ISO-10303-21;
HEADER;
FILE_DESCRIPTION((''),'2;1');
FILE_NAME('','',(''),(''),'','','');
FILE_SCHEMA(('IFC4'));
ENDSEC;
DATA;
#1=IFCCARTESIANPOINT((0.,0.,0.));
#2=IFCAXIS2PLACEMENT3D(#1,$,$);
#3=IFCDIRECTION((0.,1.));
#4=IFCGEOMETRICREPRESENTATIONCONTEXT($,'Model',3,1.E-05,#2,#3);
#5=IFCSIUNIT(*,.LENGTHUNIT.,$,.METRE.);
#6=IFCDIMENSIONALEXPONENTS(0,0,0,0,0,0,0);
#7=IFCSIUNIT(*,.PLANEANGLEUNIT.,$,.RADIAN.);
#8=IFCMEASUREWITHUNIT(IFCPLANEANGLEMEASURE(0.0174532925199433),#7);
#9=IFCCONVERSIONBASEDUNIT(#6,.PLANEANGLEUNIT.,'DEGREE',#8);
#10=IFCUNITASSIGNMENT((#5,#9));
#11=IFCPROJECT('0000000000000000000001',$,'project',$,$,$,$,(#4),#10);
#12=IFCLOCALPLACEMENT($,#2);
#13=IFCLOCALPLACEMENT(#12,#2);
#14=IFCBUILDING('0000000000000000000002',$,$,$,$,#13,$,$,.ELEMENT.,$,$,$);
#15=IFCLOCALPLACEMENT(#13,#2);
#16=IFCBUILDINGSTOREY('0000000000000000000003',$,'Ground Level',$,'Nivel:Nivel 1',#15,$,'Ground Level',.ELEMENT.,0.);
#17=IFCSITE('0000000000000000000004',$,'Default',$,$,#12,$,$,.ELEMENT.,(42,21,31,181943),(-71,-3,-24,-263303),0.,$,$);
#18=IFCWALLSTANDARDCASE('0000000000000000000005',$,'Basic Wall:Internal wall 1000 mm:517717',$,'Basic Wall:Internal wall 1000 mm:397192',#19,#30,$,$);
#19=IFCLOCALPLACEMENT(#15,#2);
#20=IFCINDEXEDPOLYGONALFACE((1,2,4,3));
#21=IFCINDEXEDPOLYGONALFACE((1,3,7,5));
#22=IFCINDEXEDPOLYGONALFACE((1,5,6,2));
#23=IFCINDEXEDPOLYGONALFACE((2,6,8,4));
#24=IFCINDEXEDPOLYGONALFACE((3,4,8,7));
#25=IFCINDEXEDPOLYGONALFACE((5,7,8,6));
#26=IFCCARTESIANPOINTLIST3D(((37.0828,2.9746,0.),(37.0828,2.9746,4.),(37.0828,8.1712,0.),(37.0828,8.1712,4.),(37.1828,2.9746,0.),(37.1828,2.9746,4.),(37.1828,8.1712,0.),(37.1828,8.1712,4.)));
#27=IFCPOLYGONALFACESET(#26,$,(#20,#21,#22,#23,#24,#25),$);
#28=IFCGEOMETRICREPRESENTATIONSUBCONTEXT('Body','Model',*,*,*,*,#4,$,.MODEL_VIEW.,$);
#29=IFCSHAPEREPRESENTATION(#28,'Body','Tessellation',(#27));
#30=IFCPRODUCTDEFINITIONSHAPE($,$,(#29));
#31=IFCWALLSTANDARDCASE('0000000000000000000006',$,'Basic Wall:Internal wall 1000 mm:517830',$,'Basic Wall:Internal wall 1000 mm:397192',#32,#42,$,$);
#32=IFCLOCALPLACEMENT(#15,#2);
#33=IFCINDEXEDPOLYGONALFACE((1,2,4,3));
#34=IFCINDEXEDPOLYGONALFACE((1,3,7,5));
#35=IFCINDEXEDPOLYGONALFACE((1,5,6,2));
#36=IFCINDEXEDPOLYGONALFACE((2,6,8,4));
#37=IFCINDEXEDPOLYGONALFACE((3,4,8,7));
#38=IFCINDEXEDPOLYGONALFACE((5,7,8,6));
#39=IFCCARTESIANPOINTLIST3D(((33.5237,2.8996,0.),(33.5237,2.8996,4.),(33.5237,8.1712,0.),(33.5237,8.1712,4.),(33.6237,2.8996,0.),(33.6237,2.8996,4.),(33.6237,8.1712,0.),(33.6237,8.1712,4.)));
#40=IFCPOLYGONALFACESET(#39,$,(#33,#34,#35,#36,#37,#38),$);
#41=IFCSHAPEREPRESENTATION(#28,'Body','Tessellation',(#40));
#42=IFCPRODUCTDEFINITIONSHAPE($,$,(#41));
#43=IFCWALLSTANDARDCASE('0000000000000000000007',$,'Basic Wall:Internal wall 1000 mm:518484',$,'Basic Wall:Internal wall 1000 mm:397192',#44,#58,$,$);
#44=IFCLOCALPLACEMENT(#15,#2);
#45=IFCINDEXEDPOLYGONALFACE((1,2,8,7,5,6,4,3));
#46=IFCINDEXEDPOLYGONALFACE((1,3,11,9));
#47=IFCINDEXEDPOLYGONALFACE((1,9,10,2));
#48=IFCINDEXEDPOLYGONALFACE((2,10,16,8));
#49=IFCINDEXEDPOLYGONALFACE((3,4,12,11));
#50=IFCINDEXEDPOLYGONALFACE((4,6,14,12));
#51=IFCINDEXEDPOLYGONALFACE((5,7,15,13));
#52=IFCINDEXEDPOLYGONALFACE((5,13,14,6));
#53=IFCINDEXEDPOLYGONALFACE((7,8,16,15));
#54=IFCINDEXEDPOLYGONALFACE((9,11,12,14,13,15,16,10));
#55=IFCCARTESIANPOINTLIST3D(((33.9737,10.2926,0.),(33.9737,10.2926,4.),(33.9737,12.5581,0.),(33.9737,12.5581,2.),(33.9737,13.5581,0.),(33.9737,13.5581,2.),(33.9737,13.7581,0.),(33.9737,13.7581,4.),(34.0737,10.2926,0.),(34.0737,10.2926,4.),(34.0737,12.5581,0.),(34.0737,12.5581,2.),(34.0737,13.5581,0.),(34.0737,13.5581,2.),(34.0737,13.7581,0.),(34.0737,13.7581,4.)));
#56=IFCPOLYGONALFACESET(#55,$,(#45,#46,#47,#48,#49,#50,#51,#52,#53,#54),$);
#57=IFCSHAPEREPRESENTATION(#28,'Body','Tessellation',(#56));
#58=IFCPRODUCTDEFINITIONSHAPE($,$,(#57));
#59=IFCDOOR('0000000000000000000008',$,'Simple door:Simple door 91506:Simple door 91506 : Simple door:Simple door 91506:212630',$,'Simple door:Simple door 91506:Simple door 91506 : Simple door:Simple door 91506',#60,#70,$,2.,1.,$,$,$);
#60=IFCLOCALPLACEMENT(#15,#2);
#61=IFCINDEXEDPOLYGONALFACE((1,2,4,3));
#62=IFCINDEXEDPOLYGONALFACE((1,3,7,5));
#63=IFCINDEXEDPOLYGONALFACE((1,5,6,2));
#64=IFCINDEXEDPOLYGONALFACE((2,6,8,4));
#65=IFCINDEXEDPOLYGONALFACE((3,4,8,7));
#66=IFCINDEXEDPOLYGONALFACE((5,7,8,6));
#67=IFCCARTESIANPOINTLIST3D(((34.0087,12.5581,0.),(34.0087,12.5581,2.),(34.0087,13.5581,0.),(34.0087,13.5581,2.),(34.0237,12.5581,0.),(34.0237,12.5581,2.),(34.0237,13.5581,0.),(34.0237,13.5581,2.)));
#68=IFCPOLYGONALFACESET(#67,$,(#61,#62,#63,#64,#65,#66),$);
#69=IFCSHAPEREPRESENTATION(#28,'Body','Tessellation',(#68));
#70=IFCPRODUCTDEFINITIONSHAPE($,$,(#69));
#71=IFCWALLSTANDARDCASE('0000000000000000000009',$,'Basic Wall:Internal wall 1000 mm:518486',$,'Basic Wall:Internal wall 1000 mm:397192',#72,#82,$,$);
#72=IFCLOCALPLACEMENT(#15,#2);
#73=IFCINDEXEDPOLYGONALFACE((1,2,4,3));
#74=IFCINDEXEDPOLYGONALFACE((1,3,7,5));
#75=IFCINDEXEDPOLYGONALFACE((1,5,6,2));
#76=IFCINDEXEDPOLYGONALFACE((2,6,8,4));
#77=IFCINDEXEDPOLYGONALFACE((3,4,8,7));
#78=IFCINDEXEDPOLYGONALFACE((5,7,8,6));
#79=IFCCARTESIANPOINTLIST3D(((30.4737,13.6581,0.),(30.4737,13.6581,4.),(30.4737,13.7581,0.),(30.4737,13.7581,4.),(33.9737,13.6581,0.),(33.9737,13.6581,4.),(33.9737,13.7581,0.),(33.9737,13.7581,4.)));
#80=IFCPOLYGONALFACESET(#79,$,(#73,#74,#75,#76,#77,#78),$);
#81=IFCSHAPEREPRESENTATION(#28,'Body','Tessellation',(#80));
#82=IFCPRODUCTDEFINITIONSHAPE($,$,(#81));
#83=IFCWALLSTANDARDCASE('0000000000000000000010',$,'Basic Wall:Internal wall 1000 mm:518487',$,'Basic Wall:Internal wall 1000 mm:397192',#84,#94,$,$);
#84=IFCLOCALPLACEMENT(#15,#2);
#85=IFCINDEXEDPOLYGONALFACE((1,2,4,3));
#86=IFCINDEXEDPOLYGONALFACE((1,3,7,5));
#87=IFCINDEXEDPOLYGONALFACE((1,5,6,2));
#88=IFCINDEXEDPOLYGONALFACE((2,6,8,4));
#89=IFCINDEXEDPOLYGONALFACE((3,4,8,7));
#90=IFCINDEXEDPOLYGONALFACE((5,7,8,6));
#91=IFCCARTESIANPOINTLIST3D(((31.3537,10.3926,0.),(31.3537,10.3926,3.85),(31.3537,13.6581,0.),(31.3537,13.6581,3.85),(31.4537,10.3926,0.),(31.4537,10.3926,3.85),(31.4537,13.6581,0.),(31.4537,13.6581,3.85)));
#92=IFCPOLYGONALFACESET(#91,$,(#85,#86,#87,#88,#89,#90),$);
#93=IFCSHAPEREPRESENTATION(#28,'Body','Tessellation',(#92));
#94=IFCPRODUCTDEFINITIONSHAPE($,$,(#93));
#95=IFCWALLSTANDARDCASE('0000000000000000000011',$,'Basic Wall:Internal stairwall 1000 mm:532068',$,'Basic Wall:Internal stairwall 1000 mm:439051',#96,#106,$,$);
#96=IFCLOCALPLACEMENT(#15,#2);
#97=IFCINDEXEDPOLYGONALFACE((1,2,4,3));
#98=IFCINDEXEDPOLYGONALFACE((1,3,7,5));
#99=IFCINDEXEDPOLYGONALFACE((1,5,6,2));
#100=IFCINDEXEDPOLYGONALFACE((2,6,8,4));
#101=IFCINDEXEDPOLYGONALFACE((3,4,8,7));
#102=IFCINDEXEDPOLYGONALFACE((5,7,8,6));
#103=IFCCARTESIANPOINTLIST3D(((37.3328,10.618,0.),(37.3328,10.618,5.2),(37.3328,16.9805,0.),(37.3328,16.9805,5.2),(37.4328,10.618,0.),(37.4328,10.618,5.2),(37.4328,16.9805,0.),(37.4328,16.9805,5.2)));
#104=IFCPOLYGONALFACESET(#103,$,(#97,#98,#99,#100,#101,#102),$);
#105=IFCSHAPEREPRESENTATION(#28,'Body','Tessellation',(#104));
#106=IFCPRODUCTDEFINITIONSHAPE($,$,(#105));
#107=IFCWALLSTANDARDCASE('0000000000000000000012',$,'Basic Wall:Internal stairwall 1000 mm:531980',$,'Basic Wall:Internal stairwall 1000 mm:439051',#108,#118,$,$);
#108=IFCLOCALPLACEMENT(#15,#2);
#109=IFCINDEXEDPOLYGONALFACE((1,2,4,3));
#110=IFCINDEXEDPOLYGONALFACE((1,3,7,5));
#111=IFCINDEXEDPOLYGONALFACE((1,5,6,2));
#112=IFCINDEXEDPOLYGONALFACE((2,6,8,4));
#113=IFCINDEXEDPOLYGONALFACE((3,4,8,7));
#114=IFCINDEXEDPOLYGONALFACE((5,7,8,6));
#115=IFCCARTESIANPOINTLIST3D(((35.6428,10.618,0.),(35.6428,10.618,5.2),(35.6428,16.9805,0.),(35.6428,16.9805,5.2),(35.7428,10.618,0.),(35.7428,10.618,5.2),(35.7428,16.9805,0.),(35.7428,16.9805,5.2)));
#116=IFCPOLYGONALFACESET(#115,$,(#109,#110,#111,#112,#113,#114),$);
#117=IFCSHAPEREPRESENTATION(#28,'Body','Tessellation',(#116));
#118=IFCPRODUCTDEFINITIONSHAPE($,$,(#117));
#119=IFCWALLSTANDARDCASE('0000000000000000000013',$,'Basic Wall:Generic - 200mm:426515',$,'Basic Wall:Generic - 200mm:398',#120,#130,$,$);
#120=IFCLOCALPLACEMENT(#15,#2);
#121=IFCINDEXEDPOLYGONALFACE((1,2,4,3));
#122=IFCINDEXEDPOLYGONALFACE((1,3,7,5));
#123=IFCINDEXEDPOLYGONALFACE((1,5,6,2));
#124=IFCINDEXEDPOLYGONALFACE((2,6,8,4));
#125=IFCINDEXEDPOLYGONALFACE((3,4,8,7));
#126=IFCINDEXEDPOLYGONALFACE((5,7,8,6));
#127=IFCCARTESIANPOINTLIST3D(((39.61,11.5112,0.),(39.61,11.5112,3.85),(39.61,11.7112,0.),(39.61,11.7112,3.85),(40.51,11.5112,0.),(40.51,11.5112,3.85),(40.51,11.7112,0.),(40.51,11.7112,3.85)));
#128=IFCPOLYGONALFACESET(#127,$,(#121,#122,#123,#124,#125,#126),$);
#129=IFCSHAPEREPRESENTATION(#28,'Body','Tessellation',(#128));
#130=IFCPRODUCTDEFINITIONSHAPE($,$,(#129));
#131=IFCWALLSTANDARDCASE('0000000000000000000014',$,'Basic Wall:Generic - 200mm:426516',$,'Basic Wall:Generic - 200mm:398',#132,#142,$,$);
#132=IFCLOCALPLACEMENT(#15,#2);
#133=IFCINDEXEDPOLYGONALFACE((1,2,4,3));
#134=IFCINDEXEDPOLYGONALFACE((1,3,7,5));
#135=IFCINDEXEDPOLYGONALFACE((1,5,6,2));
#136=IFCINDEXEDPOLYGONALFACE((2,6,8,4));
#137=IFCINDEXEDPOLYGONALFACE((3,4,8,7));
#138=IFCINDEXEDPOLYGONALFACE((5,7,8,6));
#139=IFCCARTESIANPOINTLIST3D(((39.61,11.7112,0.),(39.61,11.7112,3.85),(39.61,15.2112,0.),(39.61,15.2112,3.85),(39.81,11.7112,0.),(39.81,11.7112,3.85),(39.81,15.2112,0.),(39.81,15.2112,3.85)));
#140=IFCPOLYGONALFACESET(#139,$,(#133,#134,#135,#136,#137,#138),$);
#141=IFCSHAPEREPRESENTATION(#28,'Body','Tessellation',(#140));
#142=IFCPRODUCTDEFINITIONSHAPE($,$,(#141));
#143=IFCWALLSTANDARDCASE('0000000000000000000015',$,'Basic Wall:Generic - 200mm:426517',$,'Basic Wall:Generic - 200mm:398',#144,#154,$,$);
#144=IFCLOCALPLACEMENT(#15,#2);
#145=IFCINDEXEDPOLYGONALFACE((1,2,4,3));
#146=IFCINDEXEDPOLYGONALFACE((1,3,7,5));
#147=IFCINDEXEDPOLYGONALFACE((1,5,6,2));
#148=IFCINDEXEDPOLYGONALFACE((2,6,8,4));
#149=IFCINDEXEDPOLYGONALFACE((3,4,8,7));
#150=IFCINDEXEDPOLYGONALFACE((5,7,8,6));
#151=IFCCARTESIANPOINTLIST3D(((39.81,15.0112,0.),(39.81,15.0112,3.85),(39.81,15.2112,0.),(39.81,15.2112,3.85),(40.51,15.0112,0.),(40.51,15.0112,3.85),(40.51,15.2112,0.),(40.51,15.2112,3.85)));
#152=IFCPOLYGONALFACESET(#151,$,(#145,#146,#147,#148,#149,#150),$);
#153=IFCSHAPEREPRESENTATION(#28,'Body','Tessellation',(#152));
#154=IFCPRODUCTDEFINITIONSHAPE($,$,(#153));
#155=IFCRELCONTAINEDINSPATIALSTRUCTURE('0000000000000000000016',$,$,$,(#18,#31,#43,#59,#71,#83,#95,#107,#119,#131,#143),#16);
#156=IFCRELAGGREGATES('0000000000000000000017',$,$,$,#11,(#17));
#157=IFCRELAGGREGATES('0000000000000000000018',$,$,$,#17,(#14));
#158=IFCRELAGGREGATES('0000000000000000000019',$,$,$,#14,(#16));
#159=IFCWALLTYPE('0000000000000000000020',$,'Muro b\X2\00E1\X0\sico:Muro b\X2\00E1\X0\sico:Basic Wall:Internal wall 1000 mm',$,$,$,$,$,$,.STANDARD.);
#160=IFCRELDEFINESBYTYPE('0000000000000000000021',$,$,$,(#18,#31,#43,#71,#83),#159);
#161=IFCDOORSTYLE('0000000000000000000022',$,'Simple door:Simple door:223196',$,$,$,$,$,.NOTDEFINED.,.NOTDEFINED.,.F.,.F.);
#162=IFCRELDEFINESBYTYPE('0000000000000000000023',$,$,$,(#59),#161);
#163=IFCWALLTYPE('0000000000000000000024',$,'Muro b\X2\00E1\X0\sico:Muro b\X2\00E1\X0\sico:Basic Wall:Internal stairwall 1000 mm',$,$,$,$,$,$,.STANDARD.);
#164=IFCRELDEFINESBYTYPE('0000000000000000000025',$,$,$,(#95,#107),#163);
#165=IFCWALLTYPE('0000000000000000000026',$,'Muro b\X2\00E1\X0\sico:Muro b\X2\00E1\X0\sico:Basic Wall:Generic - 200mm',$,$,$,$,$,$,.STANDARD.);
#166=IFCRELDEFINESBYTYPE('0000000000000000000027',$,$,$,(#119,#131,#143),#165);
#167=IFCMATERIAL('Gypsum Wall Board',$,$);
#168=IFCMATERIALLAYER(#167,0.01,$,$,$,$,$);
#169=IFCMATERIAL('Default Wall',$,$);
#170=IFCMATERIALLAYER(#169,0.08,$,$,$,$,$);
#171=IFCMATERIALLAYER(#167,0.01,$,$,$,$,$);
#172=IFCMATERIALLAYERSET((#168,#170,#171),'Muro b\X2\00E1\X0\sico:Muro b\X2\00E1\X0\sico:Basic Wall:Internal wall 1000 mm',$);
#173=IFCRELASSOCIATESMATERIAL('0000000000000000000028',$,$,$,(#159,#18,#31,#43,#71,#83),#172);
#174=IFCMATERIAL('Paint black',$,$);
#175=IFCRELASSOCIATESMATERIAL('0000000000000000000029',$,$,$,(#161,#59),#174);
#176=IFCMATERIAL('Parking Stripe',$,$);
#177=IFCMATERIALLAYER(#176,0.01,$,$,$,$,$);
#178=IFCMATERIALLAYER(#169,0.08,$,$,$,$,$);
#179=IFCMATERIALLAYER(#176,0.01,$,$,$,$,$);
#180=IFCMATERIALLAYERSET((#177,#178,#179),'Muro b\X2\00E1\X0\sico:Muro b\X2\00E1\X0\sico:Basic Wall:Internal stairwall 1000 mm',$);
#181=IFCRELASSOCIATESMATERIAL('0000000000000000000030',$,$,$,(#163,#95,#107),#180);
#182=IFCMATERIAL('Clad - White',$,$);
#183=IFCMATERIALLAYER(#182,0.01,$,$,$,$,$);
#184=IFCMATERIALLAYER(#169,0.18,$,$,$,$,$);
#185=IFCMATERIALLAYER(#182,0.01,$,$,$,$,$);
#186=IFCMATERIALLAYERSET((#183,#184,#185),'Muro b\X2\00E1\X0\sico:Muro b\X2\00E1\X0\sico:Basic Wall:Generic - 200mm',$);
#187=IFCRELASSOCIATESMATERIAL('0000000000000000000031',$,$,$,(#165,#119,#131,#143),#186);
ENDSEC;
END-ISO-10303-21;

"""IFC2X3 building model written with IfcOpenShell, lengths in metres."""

from ifc_helpers import new_model, entity, si_unit, converted_unit, direction, frame, frame_2d, origin, origin_2d_with_axis, place, context, subcontext, project, spatial, rectangle, extrude, source, transform, mapped, material, layer, layer_set, layer_usage, type_object, type_shapes, element, fill, save


model = new_model("IFC2X3")

# Units and contexts
model_context = context("Model", 3, precision=1e-05, world=origin(), true_north=direction((0.0, 1.0)))
body_context = subcontext(model_context, "Body", "Model", "MODEL_VIEW")
ifc_project = project(units=[si_unit("LENGTHUNIT", "METRE"), converted_unit("PLANEANGLEUNIT", "DEGREE", entity("IfcPlaneAngleMeasure", 0.0174532925199433), si_unit("PLANEANGLEUNIT", "RADIAN"), dimensions=[0, 0, 0, 0, 0, 0, 0])], contexts=[model_context])

# Site, building, storey
site_placement = place(None, origin())
site = spatial("IfcSite", under=ifc_project, at=site_placement, Name="Default", CompositionType="ELEMENT", RefLatitude=(42, 21, 31, 181943), RefLongitude=(-71, -3, -24, -263303), RefElevation=0.0)
building_placement = place(site_placement, origin())
building = spatial("IfcBuilding", under=site, at=building_placement, CompositionType="ELEMENT")
storey_placement = place(building_placement, origin())
storey = spatial("IfcBuildingStorey", under=building, at=storey_placement, Name="Ground Level", ObjectType="Nivel:Nivel 1", LongName="Ground Level", CompositionType="ELEMENT", Elevation=0.0)

# Shared definitions
ifc_material_1 = material(Name="Gypsum Wall Board")
ifc_layer_1 = layer(ifc_material_1, 0.01)
ifc_material_2 = material(Name="Default Wall")
ifc_layer_2 = layer(ifc_material_2, 0.08)
ifc_layer_3 = layer(ifc_material_1, 0.01)
ifc_layer_set_1 = layer_set([ifc_layer_1, ifc_layer_2, ifc_layer_3], Name="Muro básico:Muro básico:Basic Wall:Internal wall 1000 mm")
wall_type_1 = type_object("IfcWallType", Name="Muro básico:Muro básico:Basic Wall:Internal wall 1000 mm", PredefinedType="STANDARD", material=ifc_layer_set_1)
ifc_material_3 = material(Name="Paint black")

# Walls
ifc_layer_usage_1 = layer_usage(ifc_layer_set_1, "AXIS2", "NEGATIVE", 0.05)
wall_1_placement = place(storey_placement, frame((37.1328, 8.1712, 0.0), z_axis=(0.0, 0.0, 1.0), x_axis=(0.0, -1.0, 0.0)))
element("IfcWallStandardCase", 1, at=wall_1_placement, inside=storey, type_object=wall_type_1, material=ifc_layer_usage_1, Name="Basic Wall:Internal wall 1000 mm:517717", ObjectType="Basic Wall:Internal wall 1000 mm:397192", context=body_context, shape_type="SweptSolid", body=[
    extrude(rectangle(XDim=5.1966, YDim=0.1, at=frame_2d((2.5983, 0.0), x_axis=(-1.0, 0.0))), origin(), (0.0, 0.0, 1.0), 4.0),
])
ifc_layer_usage_2 = layer_usage(ifc_layer_set_1, "AXIS2", "NEGATIVE", 0.05)
wall_2_placement = place(storey_placement, frame((33.5737, 8.1712, 0.0), z_axis=(0.0, 0.0, 1.0), x_axis=(0.0, -1.0, 0.0)))
element("IfcWallStandardCase", 2, at=wall_2_placement, inside=storey, type_object=wall_type_1, material=ifc_layer_usage_2, Name="Basic Wall:Internal wall 1000 mm:517830", ObjectType="Basic Wall:Internal wall 1000 mm:397192", context=body_context, shape_type="SweptSolid", body=[
    extrude(rectangle(XDim=5.2716, YDim=0.1, at=frame_2d((2.6358, 0.0), x_axis=(-1.0, 0.0))), origin(), (0.0, 0.0, 1.0), 4.0),
])

# Wall, opening, door
ifc_layer_usage_3 = layer_usage(ifc_layer_set_1, "AXIS2", "NEGATIVE", 0.05)
wall_3_placement = place(storey_placement, frame((34.0237, 10.2926, 0.0), z_axis=(0.0, 0.0, 1.0), x_axis=(0.0, 1.0, 0.0)))
wall_3 = element("IfcWallStandardCase", 3, at=wall_3_placement, inside=storey, type_object=wall_type_1, material=ifc_layer_usage_3, Name="Basic Wall:Internal wall 1000 mm:518484", ObjectType="Basic Wall:Internal wall 1000 mm:397192", context=body_context, shape_type="SweptSolid", body=[
    extrude(rectangle(XDim=3.4655, YDim=0.1, at=frame_2d((1.7328, 0.0), x_axis=(-1.0, 0.0))), origin(), (0.0, 0.0, 1.0), 4.0),
])
opening_1_placement = place(wall_3_placement, frame((-10.2926, 34.0237, 0.0), z_axis=(0.0, 0.0, 1.0), x_axis=(0.0, -1.0, 0.0)))
opening_1 = element("IfcOpeningElement", 4, at=opening_1_placement, cuts=wall_3, ObjectType="Opening", context=body_context, shape_type="SweptSolid", body=[
    extrude(rectangle(XDim=2.0, YDim=1.0, at=frame_2d((0.0, 0.0), x_axis=(0.0, 1.0))), frame((34.0757, 13.0581, 1.0), z_axis=(-1.0, 0.0, 0.0), x_axis=(0.0, -1.0, 0.0)), (0.0, 0.0, 1.0), 0.104),
])
door_style_1 = type_object("IfcDoorStyle", Name="Simple door:Simple door:223196", ConstructionType="NOTDEFINED", OperationType="NOTDEFINED", ParameterTakesPrecedence=False, Sizeable=False, material=ifc_material_3)
shared_shape_1 = source(origin(), body_context, "Body", "SweptSolid", [
    extrude(rectangle(XDim=1.0, YDim=0.015, at=origin_2d_with_axis()), frame((0.5, 0.0445, 0.0)), (0.0, 0.0, 1.0), 2.0),
])
type_shapes(door_style_1, [shared_shape_1])
door_1_placement = place(opening_1_placement, frame((33.9717, 13.5581, 0.0), z_axis=(0.0, 0.0, 1.0), x_axis=(0.0, -1.0, 0.0)))
door_1 = element("IfcDoor", 5, at=door_1_placement, inside=storey, type_object=door_style_1, material=ifc_material_3, Name="Simple door:Simple door 91506:Simple door 91506 : Simple door:Simple door 91506:212630", ObjectType="Simple door:Simple door 91506:Simple door 91506 : Simple door:Simple door 91506", OverallHeight=2.0, OverallWidth=1.0, context=body_context, shape_type="MappedRepresentation", body=[
    mapped(shared_shape_1, transform((0.0, 0.0, 0.0), scale=1.0)),
])
fill(opening_1, door_1)

# Walls
ifc_layer_usage_4 = layer_usage(ifc_layer_set_1, "AXIS2", "NEGATIVE", 0.05)
wall_4_placement = place(storey_placement, frame((33.9737, 13.7081, 0.0), z_axis=(0.0, 0.0, 1.0), x_axis=(-1.0, 0.0, 0.0)))
element("IfcWallStandardCase", 6, at=wall_4_placement, inside=storey, type_object=wall_type_1, material=ifc_layer_usage_4, Name="Basic Wall:Internal wall 1000 mm:518486", ObjectType="Basic Wall:Internal wall 1000 mm:397192", context=body_context, shape_type="SweptSolid", body=[
    extrude(rectangle(XDim=3.5, YDim=0.1, at=frame_2d((1.75, 0.0), x_axis=(-1.0, 0.0))), origin(), (0.0, 0.0, 1.0), 4.0),
])
ifc_layer_usage_5 = layer_usage(ifc_layer_set_1, "AXIS2", "NEGATIVE", 0.05)
wall_5_placement = place(storey_placement, frame((31.4037, 13.6581, 0.0), z_axis=(0.0, 0.0, 1.0), x_axis=(0.0, -1.0, 0.0)))
element("IfcWallStandardCase", 7, at=wall_5_placement, inside=storey, type_object=wall_type_1, material=ifc_layer_usage_5, Name="Basic Wall:Internal wall 1000 mm:518487", ObjectType="Basic Wall:Internal wall 1000 mm:397192", context=body_context, shape_type="SweptSolid", body=[
    extrude(rectangle(XDim=3.2655, YDim=0.1, at=frame_2d((1.6328, 0.0), x_axis=(-1.0, 0.0))), origin(), (0.0, 0.0, 1.0), 3.85),
])
ifc_material_4 = material(Name="Parking Stripe")
ifc_layer_4 = layer(ifc_material_4, 0.01)
ifc_layer_5 = layer(ifc_material_2, 0.08)
ifc_layer_6 = layer(ifc_material_4, 0.01)
ifc_layer_set_2 = layer_set([ifc_layer_4, ifc_layer_5, ifc_layer_6], Name="Muro básico:Muro básico:Basic Wall:Internal stairwall 1000 mm")
ifc_layer_usage_6 = layer_usage(ifc_layer_set_2, "AXIS2", "NEGATIVE", 0.05)
wall_type_2 = type_object("IfcWallType", Name="Muro básico:Muro básico:Basic Wall:Internal stairwall 1000 mm", PredefinedType="STANDARD", material=ifc_layer_set_2)
wall_6_placement = place(storey_placement, frame((37.3828, 10.618, 0.0), z_axis=(0.0, 0.0, 1.0), x_axis=(0.0, 1.0, 0.0)))
element("IfcWallStandardCase", 8, at=wall_6_placement, inside=storey, type_object=wall_type_2, material=ifc_layer_usage_6, Name="Basic Wall:Internal stairwall 1000 mm:532068", ObjectType="Basic Wall:Internal stairwall 1000 mm:439051", context=body_context, shape_type="SweptSolid", body=[
    extrude(rectangle(XDim=6.3625, YDim=0.1, at=frame_2d((3.1813, 0.0), x_axis=(-1.0, 0.0))), origin(), (0.0, 0.0, 1.0), 5.2),
])
ifc_layer_usage_7 = layer_usage(ifc_layer_set_2, "AXIS2", "NEGATIVE", 0.05)
wall_7_placement = place(storey_placement, frame((35.6928, 10.618, 0.0), z_axis=(0.0, 0.0, 1.0), x_axis=(0.0, 1.0, 0.0)))
element("IfcWallStandardCase", 9, at=wall_7_placement, inside=storey, type_object=wall_type_2, material=ifc_layer_usage_7, Name="Basic Wall:Internal stairwall 1000 mm:531980", ObjectType="Basic Wall:Internal stairwall 1000 mm:439051", context=body_context, shape_type="SweptSolid", body=[
    extrude(rectangle(XDim=6.3625, YDim=0.1, at=frame_2d((3.1813, 0.0), x_axis=(-1.0, 0.0))), origin(), (0.0, 0.0, 1.0), 5.2),
])
ifc_material_5 = material(Name="Clad - White")
ifc_layer_7 = layer(ifc_material_5, 0.01)
ifc_layer_8 = layer(ifc_material_2, 0.18)
ifc_layer_9 = layer(ifc_material_5, 0.01)
ifc_layer_set_3 = layer_set([ifc_layer_7, ifc_layer_8, ifc_layer_9], Name="Muro básico:Muro básico:Basic Wall:Generic - 200mm")
ifc_layer_usage_8 = layer_usage(ifc_layer_set_3, "AXIS2", "NEGATIVE", 0.1)
wall_type_3 = type_object("IfcWallType", Name="Muro básico:Muro básico:Basic Wall:Generic - 200mm", PredefinedType="STANDARD", material=ifc_layer_set_3)
wall_8_placement = place(storey_placement, frame((40.51, 11.6112, 0.0), z_axis=(0.0, 0.0, 1.0), x_axis=(-1.0, 0.0, 0.0)))
element("IfcWallStandardCase", 10, at=wall_8_placement, inside=storey, type_object=wall_type_3, material=ifc_layer_usage_8, Name="Basic Wall:Generic - 200mm:426515", ObjectType="Basic Wall:Generic - 200mm:398", context=body_context, shape_type="SweptSolid", body=[
    extrude(rectangle(XDim=0.9, YDim=0.2, at=frame_2d((0.45, 0.0), x_axis=(-1.0, 0.0))), origin(), (0.0, 0.0, 1.0), 3.85),
])
ifc_layer_usage_9 = layer_usage(ifc_layer_set_3, "AXIS2", "NEGATIVE", 0.1)
wall_9_placement = place(storey_placement, frame((39.71, 11.7112, 0.0), z_axis=(0.0, 0.0, 1.0), x_axis=(0.0, 1.0, 0.0)))
element("IfcWallStandardCase", 11, at=wall_9_placement, inside=storey, type_object=wall_type_3, material=ifc_layer_usage_9, Name="Basic Wall:Generic - 200mm:426516", ObjectType="Basic Wall:Generic - 200mm:398", context=body_context, shape_type="SweptSolid", body=[
    extrude(rectangle(XDim=3.5, YDim=0.2, at=frame_2d((1.75, 0.0), x_axis=(-1.0, 0.0))), origin(), (0.0, 0.0, 1.0), 3.85),
])
ifc_layer_usage_10 = layer_usage(ifc_layer_set_3, "AXIS2", "NEGATIVE", 0.1)
wall_10_placement = place(storey_placement, frame((39.81, 15.1112, 0.0)))
element("IfcWallStandardCase", 12, at=wall_10_placement, inside=storey, type_object=wall_type_3, material=ifc_layer_usage_10, Name="Basic Wall:Generic - 200mm:426517", ObjectType="Basic Wall:Generic - 200mm:398", context=body_context, shape_type="SweptSolid", body=[
    extrude(rectangle(XDim=0.7, YDim=0.2, at=frame_2d((0.35, 0.0), x_axis=(-1.0, 0.0))), origin(), (0.0, 0.0, 1.0), 3.85),
])

save(model, "model.ifc")
